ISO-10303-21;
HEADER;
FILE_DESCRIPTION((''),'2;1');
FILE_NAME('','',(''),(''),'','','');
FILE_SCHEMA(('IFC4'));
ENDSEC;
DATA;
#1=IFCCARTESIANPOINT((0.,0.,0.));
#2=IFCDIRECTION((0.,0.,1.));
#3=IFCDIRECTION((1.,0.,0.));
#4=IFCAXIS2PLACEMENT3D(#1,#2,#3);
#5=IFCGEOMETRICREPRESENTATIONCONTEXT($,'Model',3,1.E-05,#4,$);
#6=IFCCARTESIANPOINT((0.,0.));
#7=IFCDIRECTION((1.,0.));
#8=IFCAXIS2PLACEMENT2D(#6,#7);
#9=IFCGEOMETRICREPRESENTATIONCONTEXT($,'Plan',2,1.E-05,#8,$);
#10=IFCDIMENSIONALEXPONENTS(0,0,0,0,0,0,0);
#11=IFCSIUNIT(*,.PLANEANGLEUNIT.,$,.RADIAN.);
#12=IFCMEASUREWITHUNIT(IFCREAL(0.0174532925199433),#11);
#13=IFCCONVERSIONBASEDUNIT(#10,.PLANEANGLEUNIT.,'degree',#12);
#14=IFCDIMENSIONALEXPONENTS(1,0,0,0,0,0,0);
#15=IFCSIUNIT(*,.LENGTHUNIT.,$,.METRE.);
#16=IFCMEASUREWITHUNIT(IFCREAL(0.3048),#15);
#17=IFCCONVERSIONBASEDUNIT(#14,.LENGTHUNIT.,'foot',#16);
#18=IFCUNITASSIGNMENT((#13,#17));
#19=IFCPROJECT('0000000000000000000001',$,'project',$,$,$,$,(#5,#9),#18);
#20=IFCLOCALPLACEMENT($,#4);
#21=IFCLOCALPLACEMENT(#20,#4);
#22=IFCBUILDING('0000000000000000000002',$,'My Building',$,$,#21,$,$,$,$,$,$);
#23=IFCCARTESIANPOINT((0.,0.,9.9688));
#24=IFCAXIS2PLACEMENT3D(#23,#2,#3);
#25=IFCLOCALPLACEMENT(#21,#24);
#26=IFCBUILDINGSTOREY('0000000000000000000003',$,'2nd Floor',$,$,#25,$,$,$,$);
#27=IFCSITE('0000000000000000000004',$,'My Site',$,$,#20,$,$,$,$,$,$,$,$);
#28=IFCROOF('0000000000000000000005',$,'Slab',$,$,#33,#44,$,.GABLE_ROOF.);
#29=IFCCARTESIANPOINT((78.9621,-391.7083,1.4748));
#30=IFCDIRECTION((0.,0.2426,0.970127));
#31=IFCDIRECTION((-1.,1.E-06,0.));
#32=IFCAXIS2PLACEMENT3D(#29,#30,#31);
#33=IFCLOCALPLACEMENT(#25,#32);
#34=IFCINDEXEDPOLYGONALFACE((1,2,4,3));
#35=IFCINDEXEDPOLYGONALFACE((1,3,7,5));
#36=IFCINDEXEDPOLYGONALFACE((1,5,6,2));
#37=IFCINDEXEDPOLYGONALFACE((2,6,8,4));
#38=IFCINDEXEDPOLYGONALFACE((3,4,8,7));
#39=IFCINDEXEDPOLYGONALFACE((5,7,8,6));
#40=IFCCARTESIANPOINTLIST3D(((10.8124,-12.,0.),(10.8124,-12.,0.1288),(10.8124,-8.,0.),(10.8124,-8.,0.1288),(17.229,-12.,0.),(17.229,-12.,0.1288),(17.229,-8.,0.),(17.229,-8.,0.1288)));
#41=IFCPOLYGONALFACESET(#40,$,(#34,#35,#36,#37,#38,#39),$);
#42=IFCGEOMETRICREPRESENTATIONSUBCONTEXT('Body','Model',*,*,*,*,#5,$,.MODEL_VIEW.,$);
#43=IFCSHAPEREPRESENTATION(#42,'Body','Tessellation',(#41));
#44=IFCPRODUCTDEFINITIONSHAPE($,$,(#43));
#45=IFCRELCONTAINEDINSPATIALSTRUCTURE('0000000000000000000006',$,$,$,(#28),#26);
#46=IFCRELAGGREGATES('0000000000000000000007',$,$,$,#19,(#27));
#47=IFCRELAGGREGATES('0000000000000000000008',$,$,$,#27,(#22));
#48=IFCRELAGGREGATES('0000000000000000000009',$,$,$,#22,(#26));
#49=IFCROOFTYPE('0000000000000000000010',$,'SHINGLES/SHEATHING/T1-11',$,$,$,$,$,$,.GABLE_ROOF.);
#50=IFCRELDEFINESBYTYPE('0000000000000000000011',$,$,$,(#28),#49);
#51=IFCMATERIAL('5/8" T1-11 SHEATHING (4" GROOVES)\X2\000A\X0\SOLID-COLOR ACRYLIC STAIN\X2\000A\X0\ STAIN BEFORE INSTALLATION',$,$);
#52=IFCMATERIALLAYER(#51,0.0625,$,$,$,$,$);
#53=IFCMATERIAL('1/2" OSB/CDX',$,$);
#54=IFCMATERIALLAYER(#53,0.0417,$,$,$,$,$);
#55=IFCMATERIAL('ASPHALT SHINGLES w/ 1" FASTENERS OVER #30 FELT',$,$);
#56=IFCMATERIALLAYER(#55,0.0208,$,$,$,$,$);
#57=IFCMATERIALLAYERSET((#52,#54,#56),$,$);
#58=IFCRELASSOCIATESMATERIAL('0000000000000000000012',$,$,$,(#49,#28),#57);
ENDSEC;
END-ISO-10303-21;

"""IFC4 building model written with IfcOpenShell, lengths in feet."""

from ifc_helpers import new_model, entity, si_unit, converted_unit, frame, origin_with_axes, origin_2d_with_axis, place, context, subcontext, project, spatial, indexed_curve, outline, extrude, material, layer, layer_set, layer_usage, type_object, element, save


model = new_model("IFC4")

# Units and contexts
model_context = context("Model", 3, precision=1e-05, world=origin_with_axes())
plan_context = context("Plan", 2, precision=1e-05, world=origin_2d_with_axis())
body_context = subcontext(model_context, "Body", "Model", "MODEL_VIEW")
ifc_project = project(units=[converted_unit("PLANEANGLEUNIT", "degree", entity("IfcReal", 0.0174532925199433), si_unit("PLANEANGLEUNIT", "RADIAN"), dimensions=[0, 0, 0, 0, 0, 0, 0]), converted_unit("LENGTHUNIT", "foot", entity("IfcReal", 0.3048), si_unit("LENGTHUNIT", "METRE"), dimensions=[1, 0, 0, 0, 0, 0, 0])], contexts=[model_context, plan_context])

# Site, building, storey
site_placement = place(None, origin_with_axes())
site = spatial("IfcSite", under=ifc_project, at=site_placement, Name="My Site")
building_placement = place(site_placement, origin_with_axes())
building = spatial("IfcBuilding", under=site, at=building_placement, Name="My Building")
storey_placement = place(building_placement, frame((0.0, 0.0, 9.9688), z_axis=(0.0, 0.0, 1.0), x_axis=(1.0, 0.0, 0.0)))
storey = spatial("IfcBuildingStorey", under=building, at=storey_placement, Name="2nd Floor")

# Shared definitions
ifc_material_1 = material(Name="1/2\" OSB/CDX")
ifc_material_2 = material(Name="ASPHALT SHINGLES w/ 1\" FASTENERS OVER #30 FELT")

# Roof
ifc_material_3 = material(Name="5/8\" T1-11 SHEATHING (4\" GROOVES)\nSOLID-COLOR ACRYLIC STAIN\n STAIN BEFORE INSTALLATION")
ifc_layer_1 = layer(ifc_material_3, 0.0625)
ifc_layer_2 = layer(ifc_material_1, 0.0417)
ifc_layer_3 = layer(ifc_material_2, 0.0208)
ifc_layer_set_1 = layer_set([ifc_layer_1, ifc_layer_2, ifc_layer_3])
ifc_layer_usage_1 = layer_usage(ifc_layer_set_1, "AXIS3", "POSITIVE", 0.0)
roof_type_1 = type_object("IfcRoofType", Name="SHINGLES/SHEATHING/T1-11", PredefinedType="GABLE_ROOF", material=ifc_layer_set_1)
roof_1_placement = place(storey_placement, frame((78.9621, -391.7083, 1.4748), z_axis=(0.0, 0.2426, 0.970127), x_axis=(-1.0, 0.000001, 0.0)))
element("IfcRoof", 1, at=roof_1_placement, inside=storey, type_object=roof_type_1, material=ifc_layer_usage_1, Name="Slab", PredefinedType="GABLE_ROOF", context=body_context, shape_type="SweptSolid", body=[
    extrude(outline(indexed_curve([(17.229, -8.0), (10.8124, -8.0), (10.8124, -12.0), (17.229, -12.0), (17.229, -8.0)])), None, (0.0, 0.0, 1.0), 0.1288),
])

save(model, "model.ifc")
